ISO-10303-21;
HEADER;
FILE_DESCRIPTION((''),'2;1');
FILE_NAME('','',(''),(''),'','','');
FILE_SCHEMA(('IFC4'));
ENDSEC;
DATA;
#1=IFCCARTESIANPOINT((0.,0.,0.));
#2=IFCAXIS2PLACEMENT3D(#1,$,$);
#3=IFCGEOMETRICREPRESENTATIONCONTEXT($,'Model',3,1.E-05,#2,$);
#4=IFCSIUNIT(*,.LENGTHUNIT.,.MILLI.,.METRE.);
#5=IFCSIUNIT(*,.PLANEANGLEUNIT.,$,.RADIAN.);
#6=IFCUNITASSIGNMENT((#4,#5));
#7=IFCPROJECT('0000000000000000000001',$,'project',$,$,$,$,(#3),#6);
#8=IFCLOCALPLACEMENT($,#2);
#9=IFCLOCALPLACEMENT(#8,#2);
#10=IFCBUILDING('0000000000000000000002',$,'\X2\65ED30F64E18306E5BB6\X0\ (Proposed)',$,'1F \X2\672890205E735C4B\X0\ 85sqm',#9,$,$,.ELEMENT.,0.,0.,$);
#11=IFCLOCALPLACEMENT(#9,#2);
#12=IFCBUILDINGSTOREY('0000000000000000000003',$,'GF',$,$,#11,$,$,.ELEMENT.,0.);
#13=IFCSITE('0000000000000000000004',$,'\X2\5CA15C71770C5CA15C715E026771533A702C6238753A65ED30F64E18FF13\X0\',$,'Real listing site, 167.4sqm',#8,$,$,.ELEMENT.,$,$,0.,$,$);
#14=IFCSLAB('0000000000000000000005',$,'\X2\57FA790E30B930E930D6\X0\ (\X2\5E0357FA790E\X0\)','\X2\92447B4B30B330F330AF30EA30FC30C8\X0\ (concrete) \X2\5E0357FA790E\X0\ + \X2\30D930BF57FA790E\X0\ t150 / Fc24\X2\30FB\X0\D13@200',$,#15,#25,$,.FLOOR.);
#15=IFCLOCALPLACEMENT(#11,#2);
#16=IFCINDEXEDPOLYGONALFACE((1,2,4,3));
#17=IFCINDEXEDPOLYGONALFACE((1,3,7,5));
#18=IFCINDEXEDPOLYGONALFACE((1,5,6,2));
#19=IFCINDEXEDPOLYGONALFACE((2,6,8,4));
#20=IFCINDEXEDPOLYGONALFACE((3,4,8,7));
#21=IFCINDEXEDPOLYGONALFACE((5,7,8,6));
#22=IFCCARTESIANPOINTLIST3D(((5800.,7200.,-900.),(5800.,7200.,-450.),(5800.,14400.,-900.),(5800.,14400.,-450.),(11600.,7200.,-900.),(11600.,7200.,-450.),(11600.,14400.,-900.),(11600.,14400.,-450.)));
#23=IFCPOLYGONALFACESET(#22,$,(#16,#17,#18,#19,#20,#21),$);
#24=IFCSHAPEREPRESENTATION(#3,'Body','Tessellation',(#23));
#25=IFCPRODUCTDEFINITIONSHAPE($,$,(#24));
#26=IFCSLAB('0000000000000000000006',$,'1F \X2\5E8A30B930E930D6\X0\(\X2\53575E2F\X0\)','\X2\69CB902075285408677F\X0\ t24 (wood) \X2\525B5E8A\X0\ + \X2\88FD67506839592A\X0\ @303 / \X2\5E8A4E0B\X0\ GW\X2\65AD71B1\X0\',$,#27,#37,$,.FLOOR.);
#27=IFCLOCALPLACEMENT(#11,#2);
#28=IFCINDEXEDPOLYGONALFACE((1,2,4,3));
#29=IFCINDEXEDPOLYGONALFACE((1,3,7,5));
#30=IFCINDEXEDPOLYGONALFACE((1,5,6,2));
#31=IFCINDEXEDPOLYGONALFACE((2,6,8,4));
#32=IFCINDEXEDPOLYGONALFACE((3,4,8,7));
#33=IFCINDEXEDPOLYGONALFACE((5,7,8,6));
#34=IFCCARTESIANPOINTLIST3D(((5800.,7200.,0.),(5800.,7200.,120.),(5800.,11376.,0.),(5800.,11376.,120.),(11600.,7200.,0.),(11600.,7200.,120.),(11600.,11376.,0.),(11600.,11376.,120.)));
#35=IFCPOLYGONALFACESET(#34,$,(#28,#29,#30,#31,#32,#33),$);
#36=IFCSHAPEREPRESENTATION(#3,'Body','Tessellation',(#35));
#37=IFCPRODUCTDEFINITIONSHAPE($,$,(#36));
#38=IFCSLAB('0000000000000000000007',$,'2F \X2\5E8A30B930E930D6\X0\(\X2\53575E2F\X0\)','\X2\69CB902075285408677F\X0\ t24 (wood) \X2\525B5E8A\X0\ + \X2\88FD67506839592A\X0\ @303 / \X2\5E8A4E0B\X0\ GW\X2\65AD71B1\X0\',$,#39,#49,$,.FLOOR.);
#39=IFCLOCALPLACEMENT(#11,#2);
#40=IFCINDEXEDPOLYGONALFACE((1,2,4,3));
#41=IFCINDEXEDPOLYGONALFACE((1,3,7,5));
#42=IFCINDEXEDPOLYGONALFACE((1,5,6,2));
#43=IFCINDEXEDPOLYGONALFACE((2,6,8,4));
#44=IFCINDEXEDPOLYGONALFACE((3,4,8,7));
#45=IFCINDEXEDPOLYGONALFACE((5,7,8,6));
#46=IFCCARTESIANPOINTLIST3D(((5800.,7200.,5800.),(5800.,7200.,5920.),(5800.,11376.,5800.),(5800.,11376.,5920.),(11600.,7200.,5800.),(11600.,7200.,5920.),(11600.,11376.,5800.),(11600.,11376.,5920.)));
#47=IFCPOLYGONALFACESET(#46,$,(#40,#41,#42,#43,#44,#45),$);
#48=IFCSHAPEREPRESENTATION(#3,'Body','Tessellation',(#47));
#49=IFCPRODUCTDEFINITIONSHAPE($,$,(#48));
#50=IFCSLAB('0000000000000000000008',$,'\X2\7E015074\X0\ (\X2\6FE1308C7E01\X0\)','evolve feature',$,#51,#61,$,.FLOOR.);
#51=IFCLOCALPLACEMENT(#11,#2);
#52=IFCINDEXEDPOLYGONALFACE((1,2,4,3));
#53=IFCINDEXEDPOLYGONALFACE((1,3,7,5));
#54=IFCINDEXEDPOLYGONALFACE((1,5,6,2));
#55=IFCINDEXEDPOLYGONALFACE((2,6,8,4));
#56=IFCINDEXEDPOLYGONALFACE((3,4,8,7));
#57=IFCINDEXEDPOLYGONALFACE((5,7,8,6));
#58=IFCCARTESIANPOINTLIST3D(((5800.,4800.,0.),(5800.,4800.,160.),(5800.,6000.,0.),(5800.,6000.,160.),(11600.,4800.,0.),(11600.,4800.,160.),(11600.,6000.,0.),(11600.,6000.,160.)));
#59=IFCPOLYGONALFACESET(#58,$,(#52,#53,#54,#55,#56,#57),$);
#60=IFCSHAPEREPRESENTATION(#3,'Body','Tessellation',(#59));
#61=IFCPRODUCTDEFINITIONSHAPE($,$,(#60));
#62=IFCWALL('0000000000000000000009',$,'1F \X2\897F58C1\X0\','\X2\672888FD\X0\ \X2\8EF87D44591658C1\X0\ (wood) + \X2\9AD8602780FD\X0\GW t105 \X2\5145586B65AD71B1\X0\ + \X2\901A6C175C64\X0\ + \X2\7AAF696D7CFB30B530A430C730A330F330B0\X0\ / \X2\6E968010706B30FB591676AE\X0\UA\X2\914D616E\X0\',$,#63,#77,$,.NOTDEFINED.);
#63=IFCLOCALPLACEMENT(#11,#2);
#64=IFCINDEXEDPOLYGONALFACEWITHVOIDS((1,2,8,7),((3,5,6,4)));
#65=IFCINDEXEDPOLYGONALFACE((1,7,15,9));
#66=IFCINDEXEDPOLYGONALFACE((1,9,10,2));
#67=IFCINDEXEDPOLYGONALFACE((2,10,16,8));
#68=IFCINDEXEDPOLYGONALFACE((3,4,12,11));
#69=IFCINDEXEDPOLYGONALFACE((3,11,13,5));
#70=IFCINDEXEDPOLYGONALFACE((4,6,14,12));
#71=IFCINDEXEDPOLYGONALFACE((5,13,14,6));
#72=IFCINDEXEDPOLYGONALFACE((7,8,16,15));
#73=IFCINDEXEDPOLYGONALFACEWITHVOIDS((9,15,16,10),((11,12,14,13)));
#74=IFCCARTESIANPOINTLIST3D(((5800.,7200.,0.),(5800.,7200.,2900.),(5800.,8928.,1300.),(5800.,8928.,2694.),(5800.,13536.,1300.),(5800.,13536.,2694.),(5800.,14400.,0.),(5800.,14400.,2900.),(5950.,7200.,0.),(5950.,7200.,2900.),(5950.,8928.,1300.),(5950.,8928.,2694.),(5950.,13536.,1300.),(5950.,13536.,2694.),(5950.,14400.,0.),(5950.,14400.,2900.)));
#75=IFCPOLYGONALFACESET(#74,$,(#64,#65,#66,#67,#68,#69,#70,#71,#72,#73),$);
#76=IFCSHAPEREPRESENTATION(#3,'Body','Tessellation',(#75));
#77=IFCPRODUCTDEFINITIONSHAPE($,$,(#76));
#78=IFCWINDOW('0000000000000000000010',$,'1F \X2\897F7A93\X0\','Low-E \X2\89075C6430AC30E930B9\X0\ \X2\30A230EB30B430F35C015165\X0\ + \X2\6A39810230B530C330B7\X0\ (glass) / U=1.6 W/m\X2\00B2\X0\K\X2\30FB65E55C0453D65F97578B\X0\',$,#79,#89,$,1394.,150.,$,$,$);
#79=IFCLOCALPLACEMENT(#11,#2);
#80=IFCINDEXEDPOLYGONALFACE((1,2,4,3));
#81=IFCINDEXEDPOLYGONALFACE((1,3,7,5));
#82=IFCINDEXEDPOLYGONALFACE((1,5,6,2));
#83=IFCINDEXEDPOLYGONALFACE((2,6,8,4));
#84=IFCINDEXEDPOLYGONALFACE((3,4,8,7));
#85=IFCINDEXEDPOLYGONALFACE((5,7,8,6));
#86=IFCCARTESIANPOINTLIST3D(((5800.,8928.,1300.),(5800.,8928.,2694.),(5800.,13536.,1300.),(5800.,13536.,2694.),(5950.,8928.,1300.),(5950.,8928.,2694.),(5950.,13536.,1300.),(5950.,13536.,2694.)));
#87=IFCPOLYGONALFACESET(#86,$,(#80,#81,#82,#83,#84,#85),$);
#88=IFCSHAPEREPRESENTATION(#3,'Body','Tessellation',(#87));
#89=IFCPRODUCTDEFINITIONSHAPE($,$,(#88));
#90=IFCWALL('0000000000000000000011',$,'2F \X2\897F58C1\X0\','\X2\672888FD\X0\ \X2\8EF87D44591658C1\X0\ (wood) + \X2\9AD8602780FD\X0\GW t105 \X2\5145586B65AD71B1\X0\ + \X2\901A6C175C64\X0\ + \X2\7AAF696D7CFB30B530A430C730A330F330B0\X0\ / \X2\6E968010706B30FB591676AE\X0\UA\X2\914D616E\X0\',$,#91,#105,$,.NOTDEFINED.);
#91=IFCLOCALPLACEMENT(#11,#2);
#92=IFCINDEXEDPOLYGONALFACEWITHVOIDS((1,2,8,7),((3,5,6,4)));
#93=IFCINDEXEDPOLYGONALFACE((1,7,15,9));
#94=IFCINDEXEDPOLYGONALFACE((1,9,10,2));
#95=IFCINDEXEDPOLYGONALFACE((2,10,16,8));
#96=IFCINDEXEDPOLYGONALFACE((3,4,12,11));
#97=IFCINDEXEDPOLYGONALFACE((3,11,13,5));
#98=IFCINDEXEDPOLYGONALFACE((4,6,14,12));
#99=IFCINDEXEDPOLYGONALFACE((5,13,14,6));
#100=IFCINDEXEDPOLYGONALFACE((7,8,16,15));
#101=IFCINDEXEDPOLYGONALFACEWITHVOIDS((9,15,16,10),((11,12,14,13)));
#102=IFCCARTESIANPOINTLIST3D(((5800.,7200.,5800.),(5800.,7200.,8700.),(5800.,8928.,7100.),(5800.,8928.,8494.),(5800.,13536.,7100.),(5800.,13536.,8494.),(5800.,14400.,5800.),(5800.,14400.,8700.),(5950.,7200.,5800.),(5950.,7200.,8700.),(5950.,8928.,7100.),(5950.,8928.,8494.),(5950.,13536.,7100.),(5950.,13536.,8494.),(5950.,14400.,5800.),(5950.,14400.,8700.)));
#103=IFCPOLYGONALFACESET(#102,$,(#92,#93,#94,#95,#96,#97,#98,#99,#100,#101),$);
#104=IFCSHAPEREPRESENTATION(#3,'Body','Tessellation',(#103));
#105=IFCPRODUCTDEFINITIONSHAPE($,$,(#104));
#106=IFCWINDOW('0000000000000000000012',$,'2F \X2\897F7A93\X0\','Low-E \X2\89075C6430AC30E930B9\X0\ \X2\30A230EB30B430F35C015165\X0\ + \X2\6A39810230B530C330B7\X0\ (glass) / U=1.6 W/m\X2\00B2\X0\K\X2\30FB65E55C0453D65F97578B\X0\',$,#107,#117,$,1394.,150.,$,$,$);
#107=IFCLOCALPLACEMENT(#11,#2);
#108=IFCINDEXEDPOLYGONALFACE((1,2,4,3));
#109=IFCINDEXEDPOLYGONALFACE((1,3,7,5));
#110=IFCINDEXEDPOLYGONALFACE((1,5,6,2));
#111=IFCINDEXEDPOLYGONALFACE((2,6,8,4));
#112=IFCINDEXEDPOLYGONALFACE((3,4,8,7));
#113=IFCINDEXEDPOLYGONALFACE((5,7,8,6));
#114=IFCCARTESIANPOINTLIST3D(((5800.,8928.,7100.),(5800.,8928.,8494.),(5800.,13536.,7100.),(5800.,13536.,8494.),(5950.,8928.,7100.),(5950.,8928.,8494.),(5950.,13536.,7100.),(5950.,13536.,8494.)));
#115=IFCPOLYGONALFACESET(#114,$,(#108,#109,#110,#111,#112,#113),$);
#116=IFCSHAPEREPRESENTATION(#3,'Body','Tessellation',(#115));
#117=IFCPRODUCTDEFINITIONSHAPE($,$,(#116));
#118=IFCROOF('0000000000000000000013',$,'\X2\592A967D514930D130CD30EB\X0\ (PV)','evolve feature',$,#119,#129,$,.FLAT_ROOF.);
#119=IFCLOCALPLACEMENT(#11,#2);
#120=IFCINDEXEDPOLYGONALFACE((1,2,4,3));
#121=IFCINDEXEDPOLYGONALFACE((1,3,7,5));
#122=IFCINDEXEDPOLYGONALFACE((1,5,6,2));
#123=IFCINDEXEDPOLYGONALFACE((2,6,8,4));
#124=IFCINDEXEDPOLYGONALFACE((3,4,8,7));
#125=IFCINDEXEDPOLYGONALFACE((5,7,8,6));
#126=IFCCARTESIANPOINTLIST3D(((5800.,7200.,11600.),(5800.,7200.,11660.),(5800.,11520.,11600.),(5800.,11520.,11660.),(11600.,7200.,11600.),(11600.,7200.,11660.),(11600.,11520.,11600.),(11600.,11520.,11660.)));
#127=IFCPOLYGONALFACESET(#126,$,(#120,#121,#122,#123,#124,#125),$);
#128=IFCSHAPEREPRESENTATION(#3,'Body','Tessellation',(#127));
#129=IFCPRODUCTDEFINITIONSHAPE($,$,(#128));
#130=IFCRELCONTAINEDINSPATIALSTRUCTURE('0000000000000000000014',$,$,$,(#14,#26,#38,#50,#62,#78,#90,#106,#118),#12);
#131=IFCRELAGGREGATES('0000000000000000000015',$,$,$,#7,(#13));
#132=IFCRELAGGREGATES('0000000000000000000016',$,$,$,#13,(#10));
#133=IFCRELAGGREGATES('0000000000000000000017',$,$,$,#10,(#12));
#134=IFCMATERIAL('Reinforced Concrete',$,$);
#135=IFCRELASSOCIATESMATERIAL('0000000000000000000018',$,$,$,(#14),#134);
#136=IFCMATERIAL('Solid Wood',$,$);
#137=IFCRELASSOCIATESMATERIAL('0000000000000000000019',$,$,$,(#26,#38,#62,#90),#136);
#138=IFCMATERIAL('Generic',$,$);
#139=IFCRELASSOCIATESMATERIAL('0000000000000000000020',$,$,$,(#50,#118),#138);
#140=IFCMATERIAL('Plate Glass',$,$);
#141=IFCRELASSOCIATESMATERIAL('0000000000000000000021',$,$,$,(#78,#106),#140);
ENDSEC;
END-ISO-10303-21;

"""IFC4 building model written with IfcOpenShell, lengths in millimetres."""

from ifc_helpers import new_model, si_unit, frame, frame_2d, origin, place, context, project, spatial, rectangle, extrude, material, element, fill, save


model = new_model("IFC4")

# Units and contexts
model_context = context("Model", 3, precision=1e-05, world=origin())
ifc_project = project(units=[si_unit("LENGTHUNIT", "METRE", prefix="MILLI"), si_unit("PLANEANGLEUNIT", "RADIAN")], contexts=[model_context])

# Site, building, storey
site_placement = place(None, origin())
site = spatial("IfcSite", under=ifc_project, at=site_placement, Name="岡山県岡山市東区瀬戸町旭ヶ丘３", ObjectType="Real listing site, 167.4sqm", CompositionType="ELEMENT", RefElevation=0.0)
building_placement = place(site_placement, origin())
building = spatial("IfcBuilding", under=site, at=building_placement, Name="旭ヶ丘の家 (Proposed)", ObjectType="1F 木造平屋 85sqm", CompositionType="ELEMENT", ElevationOfRefHeight=0.0, ElevationOfTerrain=0.0)
storey_placement = place(building_placement, origin())
storey = spatial("IfcBuildingStorey", under=building, at=storey_placement, Name="GF", CompositionType="ELEMENT", Elevation=0.0)

# Slabs
ifc_material_1 = material(Name="Reinforced Concrete")
slab_1_placement = place(storey_placement, frame((2900.0, 3600.0, -450.0)))
element("IfcSlab", 1, at=slab_1_placement, inside=storey, material=ifc_material_1, Name="基礎スラブ (布基礎)", Description="鉄筋コンクリート (concrete) 布基礎 + ベタ基礎 t150 / Fc24・D13@200", PredefinedType="FLOOR", context=model_context, shape_type="SweptSolid", body=[
    extrude(rectangle(XDim=5800.0, YDim=7200.0, at=frame_2d((2900.0, 3600.0))), frame((2900.0, 3600.0, -450.0)), (0.0, 0.0, 1.0), 450.0),
])
ifc_material_2 = material(Name="Solid Wood")
slab_2_placement = place(storey_placement, frame((2900.0, 3600.0, 0.0)))
element("IfcSlab", 2, at=slab_2_placement, inside=storey, material=ifc_material_2, Name="1F 床スラブ(南帯)", Description="構造用合板 t24 (wood) 剛床 + 製材根太 @303 / 床下 GW断熱", PredefinedType="FLOOR", context=model_context, shape_type="SweptSolid", body=[
    extrude(rectangle(XDim=5800.0, YDim=4176.0, at=frame_2d((2900.0, 2088.0))), frame((2900.0, 3600.0, 0.0)), (0.0, 0.0, 1.0), 120.0),
])
slab_3_placement = place(storey_placement, frame((2900.0, 3600.0, 2900.0)))
element("IfcSlab", 3, at=slab_3_placement, inside=storey, material=ifc_material_2, Name="2F 床スラブ(南帯)", Description="構造用合板 t24 (wood) 剛床 + 製材根太 @303 / 床下 GW断熱", PredefinedType="FLOOR", context=model_context, shape_type="SweptSolid", body=[
    extrude(rectangle(XDim=5800.0, YDim=4176.0, at=frame_2d((2900.0, 2088.0))), frame((2900.0, 3600.0, 2900.0)), (0.0, 0.0, 1.0), 120.0),
])
ifc_material_3 = material(Name="Generic")
slab_4_placement = place(storey_placement, frame((2900.0, 2400.0, 0.0)))
element("IfcSlab", 4, at=slab_4_placement, inside=storey, material=ifc_material_3, Name="縁側 (濡れ縁)", Description="evolve feature", PredefinedType="FLOOR", context=model_context, shape_type="SweptSolid", body=[
    extrude(rectangle(XDim=5800.0, YDim=1200.0, at=frame_2d((2900.0, 600.0))), frame((2900.0, 2400.0, 0.0)), (0.0, 0.0, 1.0), 160.0),
])

# Shared definitions
ifc_material_4 = material(Name="Plate Glass")

# Wall, opening, window
wall_1_placement = place(storey_placement, frame((2900.0, 3600.0, 0.0)))
wall_1 = element("IfcWall", 5, at=wall_1_placement, inside=storey, material=ifc_material_2, Name="1F 西壁", Description="木製 軸組外壁 (wood) + 高性能GW t105 充填断熱 + 通気層 + 窯業系サイディング / 準耐火・外皮UA配慮", PredefinedType="NOTDEFINED", context=model_context, shape_type="SweptSolid", body=[
    extrude(rectangle(XDim=150.0, YDim=7200.0, at=frame_2d((75.0, 3600.0))), frame((2900.0, 3600.0, 0.0)), (0.0, 0.0, 1.0), 2900.0),
])
opening_1_placement = place(storey_placement, frame((2900.0, 4464.0, 650.0)))
opening_1 = element("IfcOpeningElement", 6, at=opening_1_placement, cuts=wall_1, PredefinedType="NOTDEFINED", context=model_context, shape_type="SweptSolid", body=[
    extrude(rectangle(XDim=150.0, YDim=4608.0, at=frame_2d((75.0, 2304.0))), frame((2900.0, 4464.0, 650.0)), (0.0, 0.0, 1.0), 1394.0),
])
window_1_placement = place(storey_placement, frame((2900.0, 4464.0, 650.0)))
window_1 = element("IfcWindow", 7, at=window_1_placement, inside=storey, material=ifc_material_4, Name="1F 西窓", Description="Low-E 複層ガラス アルゴン封入 + 樹脂サッシ (glass) / U=1.6 W/m²K・日射取得型", OverallHeight=1394.0, OverallWidth=150.0, context=model_context, shape_type="SweptSolid", body=[
    extrude(rectangle(XDim=150.0, YDim=4608.0, at=frame_2d((75.0, 2304.0))), frame((2900.0, 4464.0, 650.0)), (0.0, 0.0, 1.0), 1394.0),
])
fill(opening_1, window_1)

# Wall, opening, window
wall_2_placement = place(storey_placement, frame((2900.0, 3600.0, 2900.0)))
wall_2 = element("IfcWall", 8, at=wall_2_placement, inside=storey, material=ifc_material_2, Name="2F 西壁", Description="木製 軸組外壁 (wood) + 高性能GW t105 充填断熱 + 通気層 + 窯業系サイディング / 準耐火・外皮UA配慮", PredefinedType="NOTDEFINED", context=model_context, shape_type="SweptSolid", body=[
    extrude(rectangle(XDim=150.0, YDim=7200.0, at=frame_2d((75.0, 3600.0))), frame((2900.0, 3600.0, 2900.0)), (0.0, 0.0, 1.0), 2900.0),
])
opening_2_placement = place(storey_placement, frame((2900.0, 4464.0, 3550.0)))
opening_2 = element("IfcOpeningElement", 9, at=opening_2_placement, cuts=wall_2, PredefinedType="NOTDEFINED", context=model_context, shape_type="SweptSolid", body=[
    extrude(rectangle(XDim=150.0, YDim=4608.0, at=frame_2d((75.0, 2304.0))), frame((2900.0, 4464.0, 3550.0)), (0.0, 0.0, 1.0), 1394.0),
])
window_2_placement = place(storey_placement, frame((2900.0, 4464.0, 3550.0)))
window_2 = element("IfcWindow", 10, at=window_2_placement, inside=storey, material=ifc_material_4, Name="2F 西窓", Description="Low-E 複層ガラス アルゴン封入 + 樹脂サッシ (glass) / U=1.6 W/m²K・日射取得型", OverallHeight=1394.0, OverallWidth=150.0, context=model_context, shape_type="SweptSolid", body=[
    extrude(rectangle(XDim=150.0, YDim=4608.0, at=frame_2d((75.0, 2304.0))), frame((2900.0, 4464.0, 3550.0)), (0.0, 0.0, 1.0), 1394.0),
])
fill(opening_2, window_2)

# Roof
roof_placement = place(storey_placement, frame((2900.0, 3600.0, 5800.0)))
element("IfcRoof", 11, at=roof_placement, inside=storey, material=ifc_material_3, Name="太陽光パネル (PV)", Description="evolve feature", PredefinedType="FLAT_ROOF", context=model_context, shape_type="SweptSolid", body=[
    extrude(rectangle(XDim=5800.0, YDim=4320.0, at=frame_2d((2900.0, 2160.0))), frame((2900.0, 3600.0, 5800.0)), (0.0, 0.0, 1.0), 60.0),
])

save(model, "model.ifc")
